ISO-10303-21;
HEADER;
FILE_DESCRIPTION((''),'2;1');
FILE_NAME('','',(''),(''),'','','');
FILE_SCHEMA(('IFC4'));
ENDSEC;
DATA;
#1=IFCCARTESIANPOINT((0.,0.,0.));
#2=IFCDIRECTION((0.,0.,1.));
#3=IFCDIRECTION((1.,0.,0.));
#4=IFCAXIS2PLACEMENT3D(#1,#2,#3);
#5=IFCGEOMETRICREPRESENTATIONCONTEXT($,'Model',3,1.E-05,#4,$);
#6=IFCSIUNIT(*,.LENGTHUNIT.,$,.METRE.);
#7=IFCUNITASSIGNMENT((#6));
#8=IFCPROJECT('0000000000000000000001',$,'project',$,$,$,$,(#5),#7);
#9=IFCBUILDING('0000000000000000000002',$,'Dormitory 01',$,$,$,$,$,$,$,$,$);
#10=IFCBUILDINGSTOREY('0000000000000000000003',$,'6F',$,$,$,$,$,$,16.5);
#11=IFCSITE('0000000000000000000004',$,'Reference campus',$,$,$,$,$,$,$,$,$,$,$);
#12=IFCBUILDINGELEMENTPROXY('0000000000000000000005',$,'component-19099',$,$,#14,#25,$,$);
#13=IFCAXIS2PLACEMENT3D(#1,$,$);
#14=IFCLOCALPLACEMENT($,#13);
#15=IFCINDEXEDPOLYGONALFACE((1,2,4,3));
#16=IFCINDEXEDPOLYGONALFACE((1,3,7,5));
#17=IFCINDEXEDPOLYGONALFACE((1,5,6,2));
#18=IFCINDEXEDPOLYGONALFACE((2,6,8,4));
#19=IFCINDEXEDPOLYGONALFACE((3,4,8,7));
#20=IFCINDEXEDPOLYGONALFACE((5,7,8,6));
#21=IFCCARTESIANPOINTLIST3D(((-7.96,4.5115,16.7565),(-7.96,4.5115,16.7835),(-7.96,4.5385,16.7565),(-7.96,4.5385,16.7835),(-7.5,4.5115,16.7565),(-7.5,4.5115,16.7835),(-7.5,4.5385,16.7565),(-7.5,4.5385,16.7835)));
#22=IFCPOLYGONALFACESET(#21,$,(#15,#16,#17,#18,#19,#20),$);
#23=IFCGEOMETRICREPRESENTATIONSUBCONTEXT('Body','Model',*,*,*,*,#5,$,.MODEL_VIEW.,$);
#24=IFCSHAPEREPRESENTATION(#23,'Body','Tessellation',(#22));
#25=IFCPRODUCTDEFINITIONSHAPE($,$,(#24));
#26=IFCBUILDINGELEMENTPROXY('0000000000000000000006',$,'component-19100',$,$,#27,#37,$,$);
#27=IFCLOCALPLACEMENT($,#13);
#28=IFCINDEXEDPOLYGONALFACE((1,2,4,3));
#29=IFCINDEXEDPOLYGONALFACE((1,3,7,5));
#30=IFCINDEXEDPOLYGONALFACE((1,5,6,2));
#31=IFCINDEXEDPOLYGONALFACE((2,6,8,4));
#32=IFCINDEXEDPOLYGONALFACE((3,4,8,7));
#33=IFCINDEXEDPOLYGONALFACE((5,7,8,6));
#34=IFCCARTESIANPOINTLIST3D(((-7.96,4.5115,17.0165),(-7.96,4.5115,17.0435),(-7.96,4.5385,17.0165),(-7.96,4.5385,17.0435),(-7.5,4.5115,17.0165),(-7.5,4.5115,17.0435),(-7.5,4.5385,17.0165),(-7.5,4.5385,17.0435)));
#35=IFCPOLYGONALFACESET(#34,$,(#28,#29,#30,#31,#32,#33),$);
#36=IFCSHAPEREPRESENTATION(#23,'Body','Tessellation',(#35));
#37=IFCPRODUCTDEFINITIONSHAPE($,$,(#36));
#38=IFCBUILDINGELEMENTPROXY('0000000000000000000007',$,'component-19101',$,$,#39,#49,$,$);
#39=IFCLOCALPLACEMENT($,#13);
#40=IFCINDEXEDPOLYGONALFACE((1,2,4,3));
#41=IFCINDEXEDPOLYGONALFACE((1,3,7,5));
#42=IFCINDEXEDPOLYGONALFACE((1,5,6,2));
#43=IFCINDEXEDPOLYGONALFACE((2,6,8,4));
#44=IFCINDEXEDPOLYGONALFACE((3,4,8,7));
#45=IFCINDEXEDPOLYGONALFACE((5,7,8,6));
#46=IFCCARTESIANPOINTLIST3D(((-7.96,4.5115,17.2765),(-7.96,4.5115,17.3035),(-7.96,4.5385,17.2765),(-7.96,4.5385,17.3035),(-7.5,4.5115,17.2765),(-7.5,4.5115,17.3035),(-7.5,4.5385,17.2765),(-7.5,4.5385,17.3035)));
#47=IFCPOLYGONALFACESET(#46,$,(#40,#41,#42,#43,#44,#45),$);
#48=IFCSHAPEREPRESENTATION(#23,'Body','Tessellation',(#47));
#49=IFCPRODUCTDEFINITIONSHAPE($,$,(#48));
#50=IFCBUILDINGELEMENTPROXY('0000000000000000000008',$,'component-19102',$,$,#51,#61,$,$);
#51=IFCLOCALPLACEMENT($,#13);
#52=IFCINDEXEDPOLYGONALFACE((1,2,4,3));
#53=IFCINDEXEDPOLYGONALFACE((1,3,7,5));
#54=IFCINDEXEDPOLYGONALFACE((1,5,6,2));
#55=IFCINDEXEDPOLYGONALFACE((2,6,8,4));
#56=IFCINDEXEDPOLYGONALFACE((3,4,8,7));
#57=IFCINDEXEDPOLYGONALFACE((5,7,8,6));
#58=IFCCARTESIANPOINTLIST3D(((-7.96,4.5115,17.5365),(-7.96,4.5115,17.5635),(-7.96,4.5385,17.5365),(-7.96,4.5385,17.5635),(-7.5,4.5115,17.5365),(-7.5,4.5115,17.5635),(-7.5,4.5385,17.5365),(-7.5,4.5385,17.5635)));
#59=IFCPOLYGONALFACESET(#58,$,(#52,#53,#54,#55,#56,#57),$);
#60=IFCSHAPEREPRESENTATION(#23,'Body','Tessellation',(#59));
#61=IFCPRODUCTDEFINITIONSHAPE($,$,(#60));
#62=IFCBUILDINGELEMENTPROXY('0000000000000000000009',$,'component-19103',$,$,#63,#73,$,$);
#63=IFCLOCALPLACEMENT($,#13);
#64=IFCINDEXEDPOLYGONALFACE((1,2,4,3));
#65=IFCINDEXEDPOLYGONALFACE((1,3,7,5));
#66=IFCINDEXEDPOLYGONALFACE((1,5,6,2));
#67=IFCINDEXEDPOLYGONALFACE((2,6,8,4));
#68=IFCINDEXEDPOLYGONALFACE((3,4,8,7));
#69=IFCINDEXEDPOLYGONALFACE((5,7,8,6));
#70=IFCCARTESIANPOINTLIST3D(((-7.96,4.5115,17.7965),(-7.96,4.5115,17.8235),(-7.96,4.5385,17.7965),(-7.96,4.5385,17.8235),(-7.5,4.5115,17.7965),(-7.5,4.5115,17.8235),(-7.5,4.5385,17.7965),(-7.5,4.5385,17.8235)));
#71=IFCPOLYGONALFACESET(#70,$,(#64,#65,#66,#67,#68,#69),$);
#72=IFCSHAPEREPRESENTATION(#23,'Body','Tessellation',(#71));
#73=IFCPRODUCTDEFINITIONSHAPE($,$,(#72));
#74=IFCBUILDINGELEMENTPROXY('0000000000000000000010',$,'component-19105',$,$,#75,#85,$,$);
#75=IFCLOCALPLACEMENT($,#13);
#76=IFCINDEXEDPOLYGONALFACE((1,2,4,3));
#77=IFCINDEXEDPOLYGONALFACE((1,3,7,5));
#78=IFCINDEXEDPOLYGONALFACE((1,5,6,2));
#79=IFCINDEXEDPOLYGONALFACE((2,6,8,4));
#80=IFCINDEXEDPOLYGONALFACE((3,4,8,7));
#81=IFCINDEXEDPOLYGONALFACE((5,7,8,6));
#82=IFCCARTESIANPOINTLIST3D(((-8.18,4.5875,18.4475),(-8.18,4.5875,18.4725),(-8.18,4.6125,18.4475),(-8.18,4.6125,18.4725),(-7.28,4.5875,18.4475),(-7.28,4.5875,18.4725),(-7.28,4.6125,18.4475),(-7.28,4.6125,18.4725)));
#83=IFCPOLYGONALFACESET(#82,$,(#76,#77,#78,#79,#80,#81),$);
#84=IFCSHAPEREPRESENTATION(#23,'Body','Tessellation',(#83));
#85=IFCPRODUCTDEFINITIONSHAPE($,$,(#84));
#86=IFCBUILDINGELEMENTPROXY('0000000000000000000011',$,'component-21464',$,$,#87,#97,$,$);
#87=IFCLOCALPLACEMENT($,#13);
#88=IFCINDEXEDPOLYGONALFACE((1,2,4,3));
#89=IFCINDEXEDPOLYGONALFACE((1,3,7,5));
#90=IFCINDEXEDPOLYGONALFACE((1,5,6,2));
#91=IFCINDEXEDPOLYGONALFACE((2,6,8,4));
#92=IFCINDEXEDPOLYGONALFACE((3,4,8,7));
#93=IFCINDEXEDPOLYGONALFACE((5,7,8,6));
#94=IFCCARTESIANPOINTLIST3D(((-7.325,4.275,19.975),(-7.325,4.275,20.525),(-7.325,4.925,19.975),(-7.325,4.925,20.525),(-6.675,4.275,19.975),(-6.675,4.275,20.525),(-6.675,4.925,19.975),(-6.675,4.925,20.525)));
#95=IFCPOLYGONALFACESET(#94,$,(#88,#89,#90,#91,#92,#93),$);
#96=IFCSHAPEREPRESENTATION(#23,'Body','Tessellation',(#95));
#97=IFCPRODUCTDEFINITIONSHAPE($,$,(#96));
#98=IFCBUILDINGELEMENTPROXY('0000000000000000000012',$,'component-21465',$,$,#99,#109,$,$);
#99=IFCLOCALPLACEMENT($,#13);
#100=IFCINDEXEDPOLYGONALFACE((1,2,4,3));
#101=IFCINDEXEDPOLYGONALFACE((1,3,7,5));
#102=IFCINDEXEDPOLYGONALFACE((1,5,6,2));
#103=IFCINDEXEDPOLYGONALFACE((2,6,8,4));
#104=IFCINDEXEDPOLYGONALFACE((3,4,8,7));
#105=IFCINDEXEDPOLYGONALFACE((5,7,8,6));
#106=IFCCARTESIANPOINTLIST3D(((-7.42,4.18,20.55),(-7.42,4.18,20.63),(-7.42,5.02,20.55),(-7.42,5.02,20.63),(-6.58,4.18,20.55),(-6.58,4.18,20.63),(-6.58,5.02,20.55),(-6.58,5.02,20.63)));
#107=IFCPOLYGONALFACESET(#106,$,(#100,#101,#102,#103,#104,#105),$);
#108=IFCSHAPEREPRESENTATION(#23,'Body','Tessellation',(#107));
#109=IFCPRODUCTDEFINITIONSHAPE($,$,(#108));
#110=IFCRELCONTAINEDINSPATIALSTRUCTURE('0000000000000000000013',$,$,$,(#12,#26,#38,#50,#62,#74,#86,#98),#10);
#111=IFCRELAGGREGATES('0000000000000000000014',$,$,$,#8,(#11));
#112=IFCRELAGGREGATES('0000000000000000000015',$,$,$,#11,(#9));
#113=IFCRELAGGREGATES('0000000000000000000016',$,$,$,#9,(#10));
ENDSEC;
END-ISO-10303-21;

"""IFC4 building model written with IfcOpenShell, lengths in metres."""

from ifc_helpers import new_model, si_unit, frame, origin, origin_with_axes, origin_2d, place, context, subcontext, project, spatial, rectangle, extrude, element, save


model = new_model("IFC4")

# Units and contexts
model_context = context("Model", 3, precision=1e-05, world=origin_with_axes())
body_context = subcontext(model_context, "Body", "Model", "MODEL_VIEW")
ifc_project = project(units=[si_unit("LENGTHUNIT", "METRE")], contexts=[model_context])

# Site, building, storey
site = spatial("IfcSite", under=ifc_project, Name="Reference campus")
building = spatial("IfcBuilding", under=site, Name="Dormitory 01")
storey = spatial("IfcBuildingStorey", under=building, Name="6F", Elevation=16.5)

# Building element proxies
for number, where, z_axis, x_axis, name in (
    (1, (-7.73, 4.525, 16.7565), (0.0, 0.0, 1.0), (1.0, 0.0, 0.0), "component-19099"),
    (2, (-7.73, 4.525, 17.0165), (0.0, 0.0, 1.0), (1.0, 0.0, 0.0), "component-19100"),
    (3, (-7.73, 4.525, 17.2765), (0.0, 0.0, 1.0), (1.0, 0.0, 0.0), "component-19101"),
    (4, (-7.73, 4.525, 17.5365), (0.0, 0.0, 1.0), (1.0, 0.0, 0.0), "component-19102"),
    (5, (-7.73, 4.525, 17.7965), (0.0, 0.0, 1.0), (1.0, 0.0, 0.0), "component-19103"),
):
    element("IfcBuildingElementProxy", number, at=place(None, frame(where, z_axis=z_axis, x_axis=x_axis)), inside=storey, Name=name, context=body_context, shape_type="SweptSolid", body=[
        extrude(rectangle(XDim=0.46, YDim=0.027, at=origin_2d()), origin(), (0.0, 0.0, 1.0), 0.027),
    ])
proxy_1_placement = place(None, frame((-7.73, 4.6, 18.4475), z_axis=(0.0, 0.0, 1.0), x_axis=(1.0, 0.0, 0.0)))
element("IfcBuildingElementProxy", 6, at=proxy_1_placement, inside=storey, Name="component-19105", context=body_context, shape_type="SweptSolid", body=[
    extrude(rectangle(XDim=0.9, YDim=0.025, at=origin_2d()), origin(), (0.0, 0.0, 1.0), 0.025),
])
proxy_2_placement = place(None, frame((-7.0, 4.6, 19.975), z_axis=(0.0, 0.0, 1.0), x_axis=(1.0, 0.0, 0.0)))
element("IfcBuildingElementProxy", 7, at=proxy_2_placement, inside=storey, Name="component-21464", context=body_context, shape_type="SweptSolid", body=[
    extrude(rectangle(XDim=0.65, YDim=0.65, at=origin_2d()), origin(), (0.0, 0.0, 1.0), 0.55),
])
proxy_3_placement = place(None, frame((-7.0, 4.6, 20.55), z_axis=(0.0, 0.0, 1.0), x_axis=(1.0, 0.0, 0.0)))
element("IfcBuildingElementProxy", 8, at=proxy_3_placement, inside=storey, Name="component-21465", context=body_context, shape_type="SweptSolid", body=[
    extrude(rectangle(XDim=0.84, YDim=0.84, at=origin_2d()), origin(), (0.0, 0.0, 1.0), 0.08),
])

save(model, "model.ifc")
